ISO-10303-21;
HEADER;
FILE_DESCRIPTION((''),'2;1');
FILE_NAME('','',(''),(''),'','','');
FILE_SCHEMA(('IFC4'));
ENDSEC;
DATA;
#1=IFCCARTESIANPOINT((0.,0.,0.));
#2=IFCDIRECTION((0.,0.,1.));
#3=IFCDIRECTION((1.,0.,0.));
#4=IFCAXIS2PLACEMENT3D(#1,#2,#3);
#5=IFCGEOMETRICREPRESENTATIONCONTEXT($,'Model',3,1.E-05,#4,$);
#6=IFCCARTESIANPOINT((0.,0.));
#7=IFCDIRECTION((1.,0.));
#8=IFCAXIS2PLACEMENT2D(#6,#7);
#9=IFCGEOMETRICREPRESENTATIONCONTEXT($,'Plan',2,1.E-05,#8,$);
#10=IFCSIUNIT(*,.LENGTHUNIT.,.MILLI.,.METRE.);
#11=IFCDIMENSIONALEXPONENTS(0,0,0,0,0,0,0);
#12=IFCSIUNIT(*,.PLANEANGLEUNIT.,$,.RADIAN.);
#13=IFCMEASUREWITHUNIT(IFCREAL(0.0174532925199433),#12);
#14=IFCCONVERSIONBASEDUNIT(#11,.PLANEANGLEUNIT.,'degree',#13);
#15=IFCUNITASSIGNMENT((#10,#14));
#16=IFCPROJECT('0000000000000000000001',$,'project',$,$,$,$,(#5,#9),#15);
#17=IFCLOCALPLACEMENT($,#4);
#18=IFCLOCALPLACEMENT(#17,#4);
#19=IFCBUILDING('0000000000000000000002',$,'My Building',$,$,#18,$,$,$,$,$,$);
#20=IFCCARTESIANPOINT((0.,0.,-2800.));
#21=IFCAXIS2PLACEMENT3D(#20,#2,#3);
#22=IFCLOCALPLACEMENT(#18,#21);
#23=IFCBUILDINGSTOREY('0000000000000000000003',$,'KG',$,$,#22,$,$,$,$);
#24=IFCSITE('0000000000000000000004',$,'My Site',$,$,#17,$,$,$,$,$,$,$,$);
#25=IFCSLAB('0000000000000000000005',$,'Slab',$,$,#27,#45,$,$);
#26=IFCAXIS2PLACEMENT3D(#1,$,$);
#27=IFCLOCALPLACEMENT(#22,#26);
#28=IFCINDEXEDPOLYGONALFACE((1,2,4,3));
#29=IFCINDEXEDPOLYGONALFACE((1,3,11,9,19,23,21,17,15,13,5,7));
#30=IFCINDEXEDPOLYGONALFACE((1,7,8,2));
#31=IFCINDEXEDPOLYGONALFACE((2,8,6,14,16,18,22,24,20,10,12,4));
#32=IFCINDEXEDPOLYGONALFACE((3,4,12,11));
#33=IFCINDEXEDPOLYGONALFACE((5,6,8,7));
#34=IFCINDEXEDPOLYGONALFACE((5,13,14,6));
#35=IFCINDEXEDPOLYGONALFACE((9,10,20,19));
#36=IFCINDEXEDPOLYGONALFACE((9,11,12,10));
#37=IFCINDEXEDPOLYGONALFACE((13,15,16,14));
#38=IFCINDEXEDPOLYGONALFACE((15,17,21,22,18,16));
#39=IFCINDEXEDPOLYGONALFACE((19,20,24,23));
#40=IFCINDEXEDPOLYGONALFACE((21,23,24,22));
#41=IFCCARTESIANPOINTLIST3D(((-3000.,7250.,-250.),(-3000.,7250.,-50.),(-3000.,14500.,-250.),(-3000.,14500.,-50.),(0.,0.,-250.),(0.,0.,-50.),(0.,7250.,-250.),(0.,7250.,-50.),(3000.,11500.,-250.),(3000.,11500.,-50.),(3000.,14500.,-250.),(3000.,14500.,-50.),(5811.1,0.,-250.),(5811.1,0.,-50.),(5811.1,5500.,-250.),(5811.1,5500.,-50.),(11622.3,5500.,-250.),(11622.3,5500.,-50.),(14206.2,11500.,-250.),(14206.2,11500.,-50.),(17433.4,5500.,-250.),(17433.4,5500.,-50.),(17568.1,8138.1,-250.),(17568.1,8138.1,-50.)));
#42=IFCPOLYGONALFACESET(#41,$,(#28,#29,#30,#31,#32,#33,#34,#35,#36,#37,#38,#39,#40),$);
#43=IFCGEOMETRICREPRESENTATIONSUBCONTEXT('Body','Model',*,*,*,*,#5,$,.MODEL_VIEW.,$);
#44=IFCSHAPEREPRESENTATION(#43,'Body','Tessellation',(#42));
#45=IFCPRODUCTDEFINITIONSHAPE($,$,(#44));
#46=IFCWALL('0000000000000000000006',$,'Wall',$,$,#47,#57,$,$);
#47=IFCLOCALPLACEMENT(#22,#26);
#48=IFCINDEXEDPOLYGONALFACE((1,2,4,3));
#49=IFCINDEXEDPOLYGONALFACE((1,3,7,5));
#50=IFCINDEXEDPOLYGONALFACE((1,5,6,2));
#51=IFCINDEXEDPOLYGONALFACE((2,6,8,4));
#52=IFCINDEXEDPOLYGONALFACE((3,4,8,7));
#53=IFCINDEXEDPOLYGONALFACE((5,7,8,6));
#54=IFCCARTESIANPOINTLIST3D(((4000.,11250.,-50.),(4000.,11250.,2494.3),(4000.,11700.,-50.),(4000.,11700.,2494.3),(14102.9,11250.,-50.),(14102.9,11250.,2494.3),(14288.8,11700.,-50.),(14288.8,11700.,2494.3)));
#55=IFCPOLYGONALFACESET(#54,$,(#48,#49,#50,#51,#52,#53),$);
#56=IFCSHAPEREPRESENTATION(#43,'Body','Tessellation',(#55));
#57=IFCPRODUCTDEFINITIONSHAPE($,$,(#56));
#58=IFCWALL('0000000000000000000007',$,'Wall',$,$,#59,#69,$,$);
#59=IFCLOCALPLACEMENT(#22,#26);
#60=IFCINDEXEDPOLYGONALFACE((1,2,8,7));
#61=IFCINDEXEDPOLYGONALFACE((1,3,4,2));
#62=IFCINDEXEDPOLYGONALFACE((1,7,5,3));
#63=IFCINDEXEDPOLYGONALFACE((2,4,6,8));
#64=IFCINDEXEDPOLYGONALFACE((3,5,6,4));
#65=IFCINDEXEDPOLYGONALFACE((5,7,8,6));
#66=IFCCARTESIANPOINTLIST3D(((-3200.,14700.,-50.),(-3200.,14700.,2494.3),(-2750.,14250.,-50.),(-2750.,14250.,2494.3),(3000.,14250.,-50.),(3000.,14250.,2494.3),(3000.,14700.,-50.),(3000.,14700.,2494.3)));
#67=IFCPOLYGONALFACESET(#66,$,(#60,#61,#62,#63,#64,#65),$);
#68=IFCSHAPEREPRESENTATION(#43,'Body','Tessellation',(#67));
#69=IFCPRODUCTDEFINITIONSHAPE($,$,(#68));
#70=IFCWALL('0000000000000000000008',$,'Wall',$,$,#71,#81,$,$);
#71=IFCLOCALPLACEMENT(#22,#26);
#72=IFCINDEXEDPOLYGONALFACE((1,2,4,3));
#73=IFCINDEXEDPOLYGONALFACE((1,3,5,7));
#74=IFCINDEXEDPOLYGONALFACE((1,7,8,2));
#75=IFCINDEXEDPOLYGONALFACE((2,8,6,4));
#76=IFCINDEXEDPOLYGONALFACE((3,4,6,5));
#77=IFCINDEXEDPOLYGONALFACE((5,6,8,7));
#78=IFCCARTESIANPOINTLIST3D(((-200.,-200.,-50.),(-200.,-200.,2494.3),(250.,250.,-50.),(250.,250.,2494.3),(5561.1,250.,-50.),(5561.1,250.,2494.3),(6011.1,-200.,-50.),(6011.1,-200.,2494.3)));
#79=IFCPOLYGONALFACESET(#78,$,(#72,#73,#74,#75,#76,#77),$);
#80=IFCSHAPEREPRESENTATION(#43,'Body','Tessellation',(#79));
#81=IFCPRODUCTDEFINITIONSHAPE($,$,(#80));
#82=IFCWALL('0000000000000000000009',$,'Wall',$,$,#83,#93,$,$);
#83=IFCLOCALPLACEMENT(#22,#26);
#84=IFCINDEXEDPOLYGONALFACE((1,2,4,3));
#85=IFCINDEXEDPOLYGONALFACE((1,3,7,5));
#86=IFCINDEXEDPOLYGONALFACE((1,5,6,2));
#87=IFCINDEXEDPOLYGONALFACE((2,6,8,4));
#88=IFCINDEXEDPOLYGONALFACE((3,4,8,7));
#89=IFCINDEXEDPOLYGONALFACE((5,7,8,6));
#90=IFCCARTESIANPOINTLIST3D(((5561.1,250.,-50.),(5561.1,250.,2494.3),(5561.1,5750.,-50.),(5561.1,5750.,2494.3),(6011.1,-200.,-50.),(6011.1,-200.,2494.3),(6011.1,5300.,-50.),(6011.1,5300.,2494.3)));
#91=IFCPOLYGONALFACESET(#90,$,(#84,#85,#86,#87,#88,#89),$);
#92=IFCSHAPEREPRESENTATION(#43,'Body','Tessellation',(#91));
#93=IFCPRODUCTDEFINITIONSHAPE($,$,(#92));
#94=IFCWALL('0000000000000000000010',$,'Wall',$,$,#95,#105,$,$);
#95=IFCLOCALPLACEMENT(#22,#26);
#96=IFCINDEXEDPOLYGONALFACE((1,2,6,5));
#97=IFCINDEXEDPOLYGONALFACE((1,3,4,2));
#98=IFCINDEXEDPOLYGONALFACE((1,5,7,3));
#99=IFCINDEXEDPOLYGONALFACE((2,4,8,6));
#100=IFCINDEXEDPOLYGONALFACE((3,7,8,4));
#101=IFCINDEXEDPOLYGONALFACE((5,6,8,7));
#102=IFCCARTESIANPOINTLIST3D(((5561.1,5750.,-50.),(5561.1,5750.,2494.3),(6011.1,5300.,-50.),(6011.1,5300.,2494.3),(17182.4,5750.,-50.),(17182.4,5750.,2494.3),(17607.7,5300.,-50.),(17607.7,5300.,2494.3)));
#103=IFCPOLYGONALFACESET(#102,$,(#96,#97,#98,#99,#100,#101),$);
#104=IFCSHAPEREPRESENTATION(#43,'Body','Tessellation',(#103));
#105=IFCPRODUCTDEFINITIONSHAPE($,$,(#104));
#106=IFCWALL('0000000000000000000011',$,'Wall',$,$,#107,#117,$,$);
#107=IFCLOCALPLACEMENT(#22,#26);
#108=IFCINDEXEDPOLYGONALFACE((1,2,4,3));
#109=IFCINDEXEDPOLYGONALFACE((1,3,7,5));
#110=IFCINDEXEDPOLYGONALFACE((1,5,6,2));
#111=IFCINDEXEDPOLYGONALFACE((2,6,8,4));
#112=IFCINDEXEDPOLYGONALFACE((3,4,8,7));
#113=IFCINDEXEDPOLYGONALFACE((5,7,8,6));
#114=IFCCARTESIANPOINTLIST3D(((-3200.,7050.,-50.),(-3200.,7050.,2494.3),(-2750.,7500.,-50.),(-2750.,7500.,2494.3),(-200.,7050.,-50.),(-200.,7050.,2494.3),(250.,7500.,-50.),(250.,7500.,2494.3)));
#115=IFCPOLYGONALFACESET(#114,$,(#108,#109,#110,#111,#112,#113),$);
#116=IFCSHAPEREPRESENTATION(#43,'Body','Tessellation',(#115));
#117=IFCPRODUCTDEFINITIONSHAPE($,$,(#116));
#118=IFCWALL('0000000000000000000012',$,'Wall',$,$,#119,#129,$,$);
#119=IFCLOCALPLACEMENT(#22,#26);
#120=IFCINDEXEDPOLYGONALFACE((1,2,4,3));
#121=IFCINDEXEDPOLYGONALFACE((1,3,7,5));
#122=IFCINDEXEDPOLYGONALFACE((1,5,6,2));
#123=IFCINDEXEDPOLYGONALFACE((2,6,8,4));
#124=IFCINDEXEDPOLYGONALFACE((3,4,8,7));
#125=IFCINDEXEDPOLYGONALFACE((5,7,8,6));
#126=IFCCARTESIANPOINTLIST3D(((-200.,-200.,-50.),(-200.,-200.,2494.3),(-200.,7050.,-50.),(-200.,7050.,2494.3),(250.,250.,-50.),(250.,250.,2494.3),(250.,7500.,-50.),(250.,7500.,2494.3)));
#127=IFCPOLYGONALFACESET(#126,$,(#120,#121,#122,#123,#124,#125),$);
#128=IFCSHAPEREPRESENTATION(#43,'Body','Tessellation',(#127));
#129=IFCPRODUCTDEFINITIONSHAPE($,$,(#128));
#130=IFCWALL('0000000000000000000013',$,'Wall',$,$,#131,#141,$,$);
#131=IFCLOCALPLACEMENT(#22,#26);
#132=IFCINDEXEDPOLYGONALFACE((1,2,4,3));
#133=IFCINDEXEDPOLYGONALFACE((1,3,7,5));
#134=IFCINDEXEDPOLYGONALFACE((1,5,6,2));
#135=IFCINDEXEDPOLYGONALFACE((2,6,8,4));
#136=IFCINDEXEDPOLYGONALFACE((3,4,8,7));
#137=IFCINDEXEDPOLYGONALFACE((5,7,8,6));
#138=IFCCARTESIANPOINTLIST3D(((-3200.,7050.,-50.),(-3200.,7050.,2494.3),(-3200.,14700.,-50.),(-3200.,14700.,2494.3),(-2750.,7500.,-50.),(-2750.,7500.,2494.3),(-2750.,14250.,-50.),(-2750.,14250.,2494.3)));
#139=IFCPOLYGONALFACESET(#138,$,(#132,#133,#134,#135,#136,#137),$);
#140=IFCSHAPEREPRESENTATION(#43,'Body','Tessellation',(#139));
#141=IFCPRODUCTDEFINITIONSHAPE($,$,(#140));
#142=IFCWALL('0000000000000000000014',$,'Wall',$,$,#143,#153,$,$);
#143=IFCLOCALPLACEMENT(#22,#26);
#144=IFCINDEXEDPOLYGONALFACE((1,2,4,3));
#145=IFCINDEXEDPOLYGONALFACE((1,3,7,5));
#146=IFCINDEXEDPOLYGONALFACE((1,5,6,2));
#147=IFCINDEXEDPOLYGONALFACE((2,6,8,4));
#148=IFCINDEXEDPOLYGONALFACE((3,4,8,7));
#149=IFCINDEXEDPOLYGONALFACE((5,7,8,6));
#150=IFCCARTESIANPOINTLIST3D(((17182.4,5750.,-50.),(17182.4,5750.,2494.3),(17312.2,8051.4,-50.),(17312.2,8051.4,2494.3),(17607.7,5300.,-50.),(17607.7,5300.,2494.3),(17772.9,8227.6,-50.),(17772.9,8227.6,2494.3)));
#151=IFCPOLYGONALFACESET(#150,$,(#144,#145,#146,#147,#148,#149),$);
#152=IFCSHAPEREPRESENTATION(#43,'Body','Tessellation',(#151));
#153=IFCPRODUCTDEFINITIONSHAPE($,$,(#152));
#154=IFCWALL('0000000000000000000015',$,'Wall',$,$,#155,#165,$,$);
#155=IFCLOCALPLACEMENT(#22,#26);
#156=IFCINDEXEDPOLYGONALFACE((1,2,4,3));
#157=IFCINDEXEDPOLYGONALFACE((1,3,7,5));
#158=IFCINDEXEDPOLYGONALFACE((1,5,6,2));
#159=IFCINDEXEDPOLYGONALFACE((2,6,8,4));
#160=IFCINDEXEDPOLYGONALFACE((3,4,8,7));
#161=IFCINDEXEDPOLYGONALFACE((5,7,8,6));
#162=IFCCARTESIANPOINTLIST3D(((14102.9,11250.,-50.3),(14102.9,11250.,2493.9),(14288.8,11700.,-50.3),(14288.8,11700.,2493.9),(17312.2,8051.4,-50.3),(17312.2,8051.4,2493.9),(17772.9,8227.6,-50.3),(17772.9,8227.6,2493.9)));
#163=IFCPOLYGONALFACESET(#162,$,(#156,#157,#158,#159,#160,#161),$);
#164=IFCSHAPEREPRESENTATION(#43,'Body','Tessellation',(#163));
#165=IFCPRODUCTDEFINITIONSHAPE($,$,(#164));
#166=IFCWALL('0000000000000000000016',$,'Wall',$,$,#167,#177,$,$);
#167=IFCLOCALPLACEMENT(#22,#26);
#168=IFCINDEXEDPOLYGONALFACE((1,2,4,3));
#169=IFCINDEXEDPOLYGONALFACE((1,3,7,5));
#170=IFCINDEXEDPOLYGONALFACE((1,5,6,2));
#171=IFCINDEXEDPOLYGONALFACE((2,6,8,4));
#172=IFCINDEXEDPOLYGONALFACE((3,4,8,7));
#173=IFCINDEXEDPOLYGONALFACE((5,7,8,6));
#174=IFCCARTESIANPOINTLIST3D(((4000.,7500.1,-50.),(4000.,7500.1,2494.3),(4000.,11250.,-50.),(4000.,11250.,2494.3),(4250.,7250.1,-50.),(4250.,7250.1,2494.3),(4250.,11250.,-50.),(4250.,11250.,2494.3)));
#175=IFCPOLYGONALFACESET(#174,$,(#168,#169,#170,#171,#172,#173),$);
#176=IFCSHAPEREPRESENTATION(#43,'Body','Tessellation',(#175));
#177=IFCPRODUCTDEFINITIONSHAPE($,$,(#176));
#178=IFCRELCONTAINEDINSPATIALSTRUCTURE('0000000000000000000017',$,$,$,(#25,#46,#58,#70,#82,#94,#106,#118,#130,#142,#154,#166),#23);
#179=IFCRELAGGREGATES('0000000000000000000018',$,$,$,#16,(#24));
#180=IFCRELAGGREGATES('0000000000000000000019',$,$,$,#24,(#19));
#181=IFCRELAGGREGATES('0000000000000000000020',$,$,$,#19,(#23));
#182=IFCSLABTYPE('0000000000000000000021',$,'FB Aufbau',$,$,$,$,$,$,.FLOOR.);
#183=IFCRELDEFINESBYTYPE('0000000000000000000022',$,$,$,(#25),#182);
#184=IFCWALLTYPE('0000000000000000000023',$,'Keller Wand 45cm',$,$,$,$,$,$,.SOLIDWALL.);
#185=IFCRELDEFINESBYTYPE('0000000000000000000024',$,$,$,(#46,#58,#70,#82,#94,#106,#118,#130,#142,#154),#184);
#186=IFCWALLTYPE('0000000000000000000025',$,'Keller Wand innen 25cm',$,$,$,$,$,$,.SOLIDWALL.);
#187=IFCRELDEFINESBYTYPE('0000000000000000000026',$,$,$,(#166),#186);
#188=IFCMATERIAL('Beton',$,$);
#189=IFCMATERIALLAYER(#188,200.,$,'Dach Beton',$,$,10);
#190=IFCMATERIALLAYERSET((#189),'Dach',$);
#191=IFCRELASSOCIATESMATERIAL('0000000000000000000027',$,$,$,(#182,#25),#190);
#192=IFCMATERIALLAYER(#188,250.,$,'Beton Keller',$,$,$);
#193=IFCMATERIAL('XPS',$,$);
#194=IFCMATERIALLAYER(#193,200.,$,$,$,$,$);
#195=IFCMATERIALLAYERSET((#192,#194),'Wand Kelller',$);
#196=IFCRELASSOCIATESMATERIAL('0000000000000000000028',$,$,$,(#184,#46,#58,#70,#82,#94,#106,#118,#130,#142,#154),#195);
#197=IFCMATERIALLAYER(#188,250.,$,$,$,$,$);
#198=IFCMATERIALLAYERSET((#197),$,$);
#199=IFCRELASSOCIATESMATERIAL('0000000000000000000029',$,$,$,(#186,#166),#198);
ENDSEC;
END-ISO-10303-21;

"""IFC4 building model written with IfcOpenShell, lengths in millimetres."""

from ifc_helpers import new_model, entity, si_unit, converted_unit, frame, origin_with_axes, origin_2d_with_axis, place, context, subcontext, project, spatial, line, indexed_curve, outline, extrude, material, layer, layer_set, layer_usage, type_object, element, save


model = new_model("IFC4")

# Units and contexts
model_context = context("Model", 3, precision=1e-05, world=origin_with_axes())
plan_context = context("Plan", 2, precision=1e-05, world=origin_2d_with_axis())
body_context = subcontext(model_context, "Body", "Model", "MODEL_VIEW")
ifc_project = project(units=[si_unit("LENGTHUNIT", "METRE", prefix="MILLI"), converted_unit("PLANEANGLEUNIT", "degree", entity("IfcReal", 0.0174532925199433), si_unit("PLANEANGLEUNIT", "RADIAN"), dimensions=[0, 0, 0, 0, 0, 0, 0])], contexts=[model_context, plan_context])

# Site, building, storey
site_placement = place(None, origin_with_axes())
site = spatial("IfcSite", under=ifc_project, at=site_placement, Name="My Site")
building_placement = place(site_placement, origin_with_axes())
building = spatial("IfcBuilding", under=site, at=building_placement, Name="My Building")
storey_placement = place(building_placement, frame((0.0, 0.0, -2800.0), z_axis=(0.0, 0.0, 1.0), x_axis=(1.0, 0.0, 0.0)))
storey = spatial("IfcBuildingStorey", under=building, at=storey_placement, Name="KG")

# Slab
ifc_material_1 = material(Name="Beton")
ifc_layer_1 = layer(ifc_material_1, 200.0, Name="Dach Beton", Priority=10)
ifc_layer_set_1 = layer_set([ifc_layer_1], Name="Dach")
ifc_layer_usage_1 = layer_usage(ifc_layer_set_1, "AXIS3", "POSITIVE", 0.0)
slab_type = type_object("IfcSlabType", Name="FB Aufbau", PredefinedType="FLOOR", material=ifc_layer_set_1)
slab_1_placement = place(storey_placement, frame((0.0, 0.0, -250.0), z_axis=(0.0, 0.0, 1.0), x_axis=(1.0, 0.0, 0.0)))
element("IfcSlab", 1, at=slab_1_placement, inside=storey, type_object=slab_type, material=ifc_layer_usage_1, Name="Slab", context=body_context, shape_type="SweptSolid", body=[
    extrude(outline(indexed_curve([(5811.1, 5500.0), (11622.3, 5500.0), (17433.4, 5500.0), (17568.1, 8138.1), (14206.2, 11500.0), (3000.0, 11500.0), (3000.0, 14500.0), (-3000.0, 14500.0), (-3000.0, 7250.0), (0.0, 7250.0), (0.0, 0.0), (5811.1, 0.0), (5811.1, 5500.0)])), origin_with_axes(), (0.0, 0.0, 1.0), 200.0),
])

# Walls
ifc_layer_2 = layer(ifc_material_1, 250.0, Name="Beton Keller")
ifc_material_2 = material(Name="XPS")
ifc_layer_3 = layer(ifc_material_2, 200.0)
ifc_layer_set_2 = layer_set([ifc_layer_2, ifc_layer_3], Name="Wand Kelller")
ifc_layer_usage_2 = layer_usage(ifc_layer_set_2, "AXIS2", "NEGATIVE", 0.0)
wall_type_1 = type_object("IfcWallType", Name="Keller Wand 45cm", PredefinedType="SOLIDWALL", material=ifc_layer_set_2)
wall_1_placement = place(storey_placement, frame((14102.9, 11250.0, -50.0), z_axis=(0.0, 0.0, 1.0), x_axis=(-1.0, 0.0, 0.0)))
element("IfcWall", 2, at=wall_1_placement, inside=storey, type_object=wall_type_1, material=ifc_layer_usage_2, Name="Wall", context=body_context, shape_type="SweptSolid", body=[
    extrude(outline(indexed_curve([(-186.0, -450.0), (0.0, 0.0), (10102.9, 0.0), (10102.9, -450.0)], segments=[line(1, 2, 3, 4, 1)])), origin_with_axes(), (0.0, 0.0, 1.0), 2544.3),
])
ifc_layer_usage_3 = layer_usage(ifc_layer_set_2, "AXIS2", "NEGATIVE", 0.0)
wall_2_placement = place(storey_placement, frame((3000.0, 14250.0, -50.0), z_axis=(0.0, 0.0, 1.0), x_axis=(-1.0, 0.0, 0.0)))
element("IfcWall", 3, at=wall_2_placement, inside=storey, type_object=wall_type_1, material=ifc_layer_usage_3, Name="Wall", context=body_context, shape_type="SweptSolid", body=[
    extrude(outline(indexed_curve([(0.0, -450.0), (0.0, 0.0), (5750.0, 0.0), (6200.0, -450.0)], segments=[line(1, 2, 3, 4, 1)])), origin_with_axes(), (0.0, 0.0, 1.0), 2544.3),
])
ifc_layer_usage_4 = layer_usage(ifc_layer_set_2, "AXIS2", "NEGATIVE", 0.0)
wall_3_placement = place(storey_placement, frame((250.0, 250.0, -50.0), z_axis=(0.0, 0.0, 1.0), x_axis=(1.0, 0.0, 0.0)))
element("IfcWall", 4, at=wall_3_placement, inside=storey, type_object=wall_type_1, material=ifc_layer_usage_4, Name="Wall", context=body_context, shape_type="SweptSolid", body=[
    extrude(outline(indexed_curve([(-450.0, -450.0), (0.0, 0.0), (5311.1, 0.0), (5761.1, -450.0)], segments=[line(1, 2, 3, 4, 1)])), origin_with_axes(), (0.0, 0.0, 1.0), 2544.3),
])
ifc_layer_usage_5 = layer_usage(ifc_layer_set_2, "AXIS2", "NEGATIVE", 0.0)
wall_4_placement = place(storey_placement, frame((5561.1, 250.0, -50.0), z_axis=(0.0, 0.0, 1.0), x_axis=(0.0, 1.0, 0.0)))
element("IfcWall", 5, at=wall_4_placement, inside=storey, type_object=wall_type_1, material=ifc_layer_usage_5, Name="Wall", context=body_context, shape_type="SweptSolid", body=[
    extrude(outline(indexed_curve([(-450.0, -450.0), (0.0, 0.0), (5500.0, 0.0), (5050.0, -450.0)], segments=[line(1, 2, 3, 4, 1)])), origin_with_axes(), (0.0, 0.0, 1.0), 2544.3),
])
ifc_layer_usage_6 = layer_usage(ifc_layer_set_2, "AXIS2", "NEGATIVE", 0.0)
wall_5_placement = place(storey_placement, frame((5561.1, 5750.0, -50.0), z_axis=(0.0, 0.0, 1.0), x_axis=(1.0, 0.0, 0.0)))
element("IfcWall", 6, at=wall_5_placement, inside=storey, type_object=wall_type_1, material=ifc_layer_usage_6, Name="Wall", context=body_context, shape_type="SweptSolid", body=[
    extrude(outline(indexed_curve([(450.0, -450.0), (0.0, 0.0), (11621.2, 0.0), (12046.6, -450.0)], segments=[line(1, 2, 3, 4, 1)])), origin_with_axes(), (0.0, 0.0, 1.0), 2544.3),
])
ifc_layer_usage_7 = layer_usage(ifc_layer_set_2, "AXIS2", "POSITIVE", 0.0)
wall_6_placement = place(storey_placement, frame((250.0, 7500.0, -50.0), z_axis=(0.0, 0.0, 1.0), x_axis=(-1.0, 0.0, 0.0)))
element("IfcWall", 7, at=wall_6_placement, inside=storey, type_object=wall_type_1, material=ifc_layer_usage_7, Name="Wall", context=body_context, shape_type="SweptSolid", body=[
    extrude(outline(indexed_curve([(0.0, 0.0), (450.0, 450.0), (3450.0, 450.0), (3000.0, 0.0)], segments=[line(1, 2, 3, 4, 1)])), origin_with_axes(), (0.0, 0.0, 1.0), 2544.3),
])
ifc_layer_usage_8 = layer_usage(ifc_layer_set_2, "AXIS2", "NEGATIVE", 0.0)
wall_7_placement = place(storey_placement, frame((250.0, 7500.0, -50.0), z_axis=(0.0, 0.0, 1.0), x_axis=(0.0, -1.0, 0.0)))
element("IfcWall", 8, at=wall_7_placement, inside=storey, type_object=wall_type_1, material=ifc_layer_usage_8, Name="Wall", context=body_context, shape_type="SweptSolid", body=[
    extrude(outline(indexed_curve([(450.0, -450.0), (0.0, 0.0), (7250.0, 0.0), (7700.0, -450.0)], segments=[line(1, 2, 3, 4, 1)])), origin_with_axes(), (0.0, 0.0, 1.0), 2544.3),
])
ifc_layer_usage_9 = layer_usage(ifc_layer_set_2, "AXIS2", "NEGATIVE", 0.0)
wall_8_placement = place(storey_placement, frame((-2750.0, 14250.0, -50.0), z_axis=(0.0, 0.0, 1.0), x_axis=(0.0, -1.0, 0.0)))
element("IfcWall", 9, at=wall_8_placement, inside=storey, type_object=wall_type_1, material=ifc_layer_usage_9, Name="Wall", context=body_context, shape_type="SweptSolid", body=[
    extrude(outline(indexed_curve([(-450.0, -450.0), (0.0, 0.0), (6750.0, 0.0), (7200.0, -450.0)], segments=[line(1, 2, 3, 4, 1)])), origin_with_axes(), (0.0, 0.0, 1.0), 2544.3),
])
ifc_layer_usage_10 = layer_usage(ifc_layer_set_2, "AXIS2", "NEGATIVE", 0.0)
wall_9_placement = place(storey_placement, frame((17182.4, 5750.0, -50.0), z_axis=(0.0, 0.0, 1.0), x_axis=(0.056323, 0.998413, 0.0)))
element("IfcWall", 10, at=wall_9_placement, inside=storey, type_object=wall_type_1, material=ifc_layer_usage_10, Name="Wall", context=body_context, shape_type="SweptSolid", body=[
    extrude(outline(indexed_curve([(-425.3, -450.0), (0.0, 0.0), (2305.1, 0.0), (2507.0, -450.0)], segments=[line(1, 2, 3, 4, 1)])), origin_with_axes(), (0.0, 0.0, 1.0), 2544.3),
])
ifc_layer_usage_11 = layer_usage(ifc_layer_set_2, "AXIS2", "NEGATIVE", 0.0)
wall_10_placement = place(storey_placement, frame((17312.2, 8051.4, -50.3), z_axis=(0.0, 0.0, 1.0), x_axis=(-0.70829, 0.705921, 0.0)))
element("IfcWall", 11, at=wall_10_placement, inside=storey, type_object=wall_type_1, material=ifc_layer_usage_11, Name="Wall", context=body_context, shape_type="SweptSolid", body=[
    extrude(outline(indexed_curve([(-201.9, -450.0), (0.0, 0.0), (4531.1, 0.0), (4717.0, -450.0)], segments=[line(1, 2, 3, 4, 1)])), origin_with_axes(), (0.0, 0.0, 1.0), 2544.3),
])
ifc_layer_4 = layer(ifc_material_1, 250.0)
ifc_layer_set_3 = layer_set([ifc_layer_4])
ifc_layer_usage_12 = layer_usage(ifc_layer_set_3, "AXIS2", "POSITIVE", 0.0)
wall_type_2 = type_object("IfcWallType", Name="Keller Wand innen 25cm", PredefinedType="SOLIDWALL", material=ifc_layer_set_3)
wall_11_placement = place(storey_placement, frame((4000.0, 11250.0, -50.0), z_axis=(0.0, 0.0, 1.0), x_axis=(0.0, -1.0, 0.0)))
element("IfcWall", 12, at=wall_11_placement, inside=storey, type_object=wall_type_2, material=ifc_layer_usage_12, Name="Wall", context=body_context, shape_type="SweptSolid", body=[
    extrude(outline(indexed_curve([(0.0, 0.0), (0.0, 250.0), (3999.9, 250.0), (3749.9, 0.0)], segments=[line(1, 2, 3, 4, 1)])), origin_with_axes(), (0.0, 0.0, 1.0), 2544.3),
])

save(model, "model.ifc")
